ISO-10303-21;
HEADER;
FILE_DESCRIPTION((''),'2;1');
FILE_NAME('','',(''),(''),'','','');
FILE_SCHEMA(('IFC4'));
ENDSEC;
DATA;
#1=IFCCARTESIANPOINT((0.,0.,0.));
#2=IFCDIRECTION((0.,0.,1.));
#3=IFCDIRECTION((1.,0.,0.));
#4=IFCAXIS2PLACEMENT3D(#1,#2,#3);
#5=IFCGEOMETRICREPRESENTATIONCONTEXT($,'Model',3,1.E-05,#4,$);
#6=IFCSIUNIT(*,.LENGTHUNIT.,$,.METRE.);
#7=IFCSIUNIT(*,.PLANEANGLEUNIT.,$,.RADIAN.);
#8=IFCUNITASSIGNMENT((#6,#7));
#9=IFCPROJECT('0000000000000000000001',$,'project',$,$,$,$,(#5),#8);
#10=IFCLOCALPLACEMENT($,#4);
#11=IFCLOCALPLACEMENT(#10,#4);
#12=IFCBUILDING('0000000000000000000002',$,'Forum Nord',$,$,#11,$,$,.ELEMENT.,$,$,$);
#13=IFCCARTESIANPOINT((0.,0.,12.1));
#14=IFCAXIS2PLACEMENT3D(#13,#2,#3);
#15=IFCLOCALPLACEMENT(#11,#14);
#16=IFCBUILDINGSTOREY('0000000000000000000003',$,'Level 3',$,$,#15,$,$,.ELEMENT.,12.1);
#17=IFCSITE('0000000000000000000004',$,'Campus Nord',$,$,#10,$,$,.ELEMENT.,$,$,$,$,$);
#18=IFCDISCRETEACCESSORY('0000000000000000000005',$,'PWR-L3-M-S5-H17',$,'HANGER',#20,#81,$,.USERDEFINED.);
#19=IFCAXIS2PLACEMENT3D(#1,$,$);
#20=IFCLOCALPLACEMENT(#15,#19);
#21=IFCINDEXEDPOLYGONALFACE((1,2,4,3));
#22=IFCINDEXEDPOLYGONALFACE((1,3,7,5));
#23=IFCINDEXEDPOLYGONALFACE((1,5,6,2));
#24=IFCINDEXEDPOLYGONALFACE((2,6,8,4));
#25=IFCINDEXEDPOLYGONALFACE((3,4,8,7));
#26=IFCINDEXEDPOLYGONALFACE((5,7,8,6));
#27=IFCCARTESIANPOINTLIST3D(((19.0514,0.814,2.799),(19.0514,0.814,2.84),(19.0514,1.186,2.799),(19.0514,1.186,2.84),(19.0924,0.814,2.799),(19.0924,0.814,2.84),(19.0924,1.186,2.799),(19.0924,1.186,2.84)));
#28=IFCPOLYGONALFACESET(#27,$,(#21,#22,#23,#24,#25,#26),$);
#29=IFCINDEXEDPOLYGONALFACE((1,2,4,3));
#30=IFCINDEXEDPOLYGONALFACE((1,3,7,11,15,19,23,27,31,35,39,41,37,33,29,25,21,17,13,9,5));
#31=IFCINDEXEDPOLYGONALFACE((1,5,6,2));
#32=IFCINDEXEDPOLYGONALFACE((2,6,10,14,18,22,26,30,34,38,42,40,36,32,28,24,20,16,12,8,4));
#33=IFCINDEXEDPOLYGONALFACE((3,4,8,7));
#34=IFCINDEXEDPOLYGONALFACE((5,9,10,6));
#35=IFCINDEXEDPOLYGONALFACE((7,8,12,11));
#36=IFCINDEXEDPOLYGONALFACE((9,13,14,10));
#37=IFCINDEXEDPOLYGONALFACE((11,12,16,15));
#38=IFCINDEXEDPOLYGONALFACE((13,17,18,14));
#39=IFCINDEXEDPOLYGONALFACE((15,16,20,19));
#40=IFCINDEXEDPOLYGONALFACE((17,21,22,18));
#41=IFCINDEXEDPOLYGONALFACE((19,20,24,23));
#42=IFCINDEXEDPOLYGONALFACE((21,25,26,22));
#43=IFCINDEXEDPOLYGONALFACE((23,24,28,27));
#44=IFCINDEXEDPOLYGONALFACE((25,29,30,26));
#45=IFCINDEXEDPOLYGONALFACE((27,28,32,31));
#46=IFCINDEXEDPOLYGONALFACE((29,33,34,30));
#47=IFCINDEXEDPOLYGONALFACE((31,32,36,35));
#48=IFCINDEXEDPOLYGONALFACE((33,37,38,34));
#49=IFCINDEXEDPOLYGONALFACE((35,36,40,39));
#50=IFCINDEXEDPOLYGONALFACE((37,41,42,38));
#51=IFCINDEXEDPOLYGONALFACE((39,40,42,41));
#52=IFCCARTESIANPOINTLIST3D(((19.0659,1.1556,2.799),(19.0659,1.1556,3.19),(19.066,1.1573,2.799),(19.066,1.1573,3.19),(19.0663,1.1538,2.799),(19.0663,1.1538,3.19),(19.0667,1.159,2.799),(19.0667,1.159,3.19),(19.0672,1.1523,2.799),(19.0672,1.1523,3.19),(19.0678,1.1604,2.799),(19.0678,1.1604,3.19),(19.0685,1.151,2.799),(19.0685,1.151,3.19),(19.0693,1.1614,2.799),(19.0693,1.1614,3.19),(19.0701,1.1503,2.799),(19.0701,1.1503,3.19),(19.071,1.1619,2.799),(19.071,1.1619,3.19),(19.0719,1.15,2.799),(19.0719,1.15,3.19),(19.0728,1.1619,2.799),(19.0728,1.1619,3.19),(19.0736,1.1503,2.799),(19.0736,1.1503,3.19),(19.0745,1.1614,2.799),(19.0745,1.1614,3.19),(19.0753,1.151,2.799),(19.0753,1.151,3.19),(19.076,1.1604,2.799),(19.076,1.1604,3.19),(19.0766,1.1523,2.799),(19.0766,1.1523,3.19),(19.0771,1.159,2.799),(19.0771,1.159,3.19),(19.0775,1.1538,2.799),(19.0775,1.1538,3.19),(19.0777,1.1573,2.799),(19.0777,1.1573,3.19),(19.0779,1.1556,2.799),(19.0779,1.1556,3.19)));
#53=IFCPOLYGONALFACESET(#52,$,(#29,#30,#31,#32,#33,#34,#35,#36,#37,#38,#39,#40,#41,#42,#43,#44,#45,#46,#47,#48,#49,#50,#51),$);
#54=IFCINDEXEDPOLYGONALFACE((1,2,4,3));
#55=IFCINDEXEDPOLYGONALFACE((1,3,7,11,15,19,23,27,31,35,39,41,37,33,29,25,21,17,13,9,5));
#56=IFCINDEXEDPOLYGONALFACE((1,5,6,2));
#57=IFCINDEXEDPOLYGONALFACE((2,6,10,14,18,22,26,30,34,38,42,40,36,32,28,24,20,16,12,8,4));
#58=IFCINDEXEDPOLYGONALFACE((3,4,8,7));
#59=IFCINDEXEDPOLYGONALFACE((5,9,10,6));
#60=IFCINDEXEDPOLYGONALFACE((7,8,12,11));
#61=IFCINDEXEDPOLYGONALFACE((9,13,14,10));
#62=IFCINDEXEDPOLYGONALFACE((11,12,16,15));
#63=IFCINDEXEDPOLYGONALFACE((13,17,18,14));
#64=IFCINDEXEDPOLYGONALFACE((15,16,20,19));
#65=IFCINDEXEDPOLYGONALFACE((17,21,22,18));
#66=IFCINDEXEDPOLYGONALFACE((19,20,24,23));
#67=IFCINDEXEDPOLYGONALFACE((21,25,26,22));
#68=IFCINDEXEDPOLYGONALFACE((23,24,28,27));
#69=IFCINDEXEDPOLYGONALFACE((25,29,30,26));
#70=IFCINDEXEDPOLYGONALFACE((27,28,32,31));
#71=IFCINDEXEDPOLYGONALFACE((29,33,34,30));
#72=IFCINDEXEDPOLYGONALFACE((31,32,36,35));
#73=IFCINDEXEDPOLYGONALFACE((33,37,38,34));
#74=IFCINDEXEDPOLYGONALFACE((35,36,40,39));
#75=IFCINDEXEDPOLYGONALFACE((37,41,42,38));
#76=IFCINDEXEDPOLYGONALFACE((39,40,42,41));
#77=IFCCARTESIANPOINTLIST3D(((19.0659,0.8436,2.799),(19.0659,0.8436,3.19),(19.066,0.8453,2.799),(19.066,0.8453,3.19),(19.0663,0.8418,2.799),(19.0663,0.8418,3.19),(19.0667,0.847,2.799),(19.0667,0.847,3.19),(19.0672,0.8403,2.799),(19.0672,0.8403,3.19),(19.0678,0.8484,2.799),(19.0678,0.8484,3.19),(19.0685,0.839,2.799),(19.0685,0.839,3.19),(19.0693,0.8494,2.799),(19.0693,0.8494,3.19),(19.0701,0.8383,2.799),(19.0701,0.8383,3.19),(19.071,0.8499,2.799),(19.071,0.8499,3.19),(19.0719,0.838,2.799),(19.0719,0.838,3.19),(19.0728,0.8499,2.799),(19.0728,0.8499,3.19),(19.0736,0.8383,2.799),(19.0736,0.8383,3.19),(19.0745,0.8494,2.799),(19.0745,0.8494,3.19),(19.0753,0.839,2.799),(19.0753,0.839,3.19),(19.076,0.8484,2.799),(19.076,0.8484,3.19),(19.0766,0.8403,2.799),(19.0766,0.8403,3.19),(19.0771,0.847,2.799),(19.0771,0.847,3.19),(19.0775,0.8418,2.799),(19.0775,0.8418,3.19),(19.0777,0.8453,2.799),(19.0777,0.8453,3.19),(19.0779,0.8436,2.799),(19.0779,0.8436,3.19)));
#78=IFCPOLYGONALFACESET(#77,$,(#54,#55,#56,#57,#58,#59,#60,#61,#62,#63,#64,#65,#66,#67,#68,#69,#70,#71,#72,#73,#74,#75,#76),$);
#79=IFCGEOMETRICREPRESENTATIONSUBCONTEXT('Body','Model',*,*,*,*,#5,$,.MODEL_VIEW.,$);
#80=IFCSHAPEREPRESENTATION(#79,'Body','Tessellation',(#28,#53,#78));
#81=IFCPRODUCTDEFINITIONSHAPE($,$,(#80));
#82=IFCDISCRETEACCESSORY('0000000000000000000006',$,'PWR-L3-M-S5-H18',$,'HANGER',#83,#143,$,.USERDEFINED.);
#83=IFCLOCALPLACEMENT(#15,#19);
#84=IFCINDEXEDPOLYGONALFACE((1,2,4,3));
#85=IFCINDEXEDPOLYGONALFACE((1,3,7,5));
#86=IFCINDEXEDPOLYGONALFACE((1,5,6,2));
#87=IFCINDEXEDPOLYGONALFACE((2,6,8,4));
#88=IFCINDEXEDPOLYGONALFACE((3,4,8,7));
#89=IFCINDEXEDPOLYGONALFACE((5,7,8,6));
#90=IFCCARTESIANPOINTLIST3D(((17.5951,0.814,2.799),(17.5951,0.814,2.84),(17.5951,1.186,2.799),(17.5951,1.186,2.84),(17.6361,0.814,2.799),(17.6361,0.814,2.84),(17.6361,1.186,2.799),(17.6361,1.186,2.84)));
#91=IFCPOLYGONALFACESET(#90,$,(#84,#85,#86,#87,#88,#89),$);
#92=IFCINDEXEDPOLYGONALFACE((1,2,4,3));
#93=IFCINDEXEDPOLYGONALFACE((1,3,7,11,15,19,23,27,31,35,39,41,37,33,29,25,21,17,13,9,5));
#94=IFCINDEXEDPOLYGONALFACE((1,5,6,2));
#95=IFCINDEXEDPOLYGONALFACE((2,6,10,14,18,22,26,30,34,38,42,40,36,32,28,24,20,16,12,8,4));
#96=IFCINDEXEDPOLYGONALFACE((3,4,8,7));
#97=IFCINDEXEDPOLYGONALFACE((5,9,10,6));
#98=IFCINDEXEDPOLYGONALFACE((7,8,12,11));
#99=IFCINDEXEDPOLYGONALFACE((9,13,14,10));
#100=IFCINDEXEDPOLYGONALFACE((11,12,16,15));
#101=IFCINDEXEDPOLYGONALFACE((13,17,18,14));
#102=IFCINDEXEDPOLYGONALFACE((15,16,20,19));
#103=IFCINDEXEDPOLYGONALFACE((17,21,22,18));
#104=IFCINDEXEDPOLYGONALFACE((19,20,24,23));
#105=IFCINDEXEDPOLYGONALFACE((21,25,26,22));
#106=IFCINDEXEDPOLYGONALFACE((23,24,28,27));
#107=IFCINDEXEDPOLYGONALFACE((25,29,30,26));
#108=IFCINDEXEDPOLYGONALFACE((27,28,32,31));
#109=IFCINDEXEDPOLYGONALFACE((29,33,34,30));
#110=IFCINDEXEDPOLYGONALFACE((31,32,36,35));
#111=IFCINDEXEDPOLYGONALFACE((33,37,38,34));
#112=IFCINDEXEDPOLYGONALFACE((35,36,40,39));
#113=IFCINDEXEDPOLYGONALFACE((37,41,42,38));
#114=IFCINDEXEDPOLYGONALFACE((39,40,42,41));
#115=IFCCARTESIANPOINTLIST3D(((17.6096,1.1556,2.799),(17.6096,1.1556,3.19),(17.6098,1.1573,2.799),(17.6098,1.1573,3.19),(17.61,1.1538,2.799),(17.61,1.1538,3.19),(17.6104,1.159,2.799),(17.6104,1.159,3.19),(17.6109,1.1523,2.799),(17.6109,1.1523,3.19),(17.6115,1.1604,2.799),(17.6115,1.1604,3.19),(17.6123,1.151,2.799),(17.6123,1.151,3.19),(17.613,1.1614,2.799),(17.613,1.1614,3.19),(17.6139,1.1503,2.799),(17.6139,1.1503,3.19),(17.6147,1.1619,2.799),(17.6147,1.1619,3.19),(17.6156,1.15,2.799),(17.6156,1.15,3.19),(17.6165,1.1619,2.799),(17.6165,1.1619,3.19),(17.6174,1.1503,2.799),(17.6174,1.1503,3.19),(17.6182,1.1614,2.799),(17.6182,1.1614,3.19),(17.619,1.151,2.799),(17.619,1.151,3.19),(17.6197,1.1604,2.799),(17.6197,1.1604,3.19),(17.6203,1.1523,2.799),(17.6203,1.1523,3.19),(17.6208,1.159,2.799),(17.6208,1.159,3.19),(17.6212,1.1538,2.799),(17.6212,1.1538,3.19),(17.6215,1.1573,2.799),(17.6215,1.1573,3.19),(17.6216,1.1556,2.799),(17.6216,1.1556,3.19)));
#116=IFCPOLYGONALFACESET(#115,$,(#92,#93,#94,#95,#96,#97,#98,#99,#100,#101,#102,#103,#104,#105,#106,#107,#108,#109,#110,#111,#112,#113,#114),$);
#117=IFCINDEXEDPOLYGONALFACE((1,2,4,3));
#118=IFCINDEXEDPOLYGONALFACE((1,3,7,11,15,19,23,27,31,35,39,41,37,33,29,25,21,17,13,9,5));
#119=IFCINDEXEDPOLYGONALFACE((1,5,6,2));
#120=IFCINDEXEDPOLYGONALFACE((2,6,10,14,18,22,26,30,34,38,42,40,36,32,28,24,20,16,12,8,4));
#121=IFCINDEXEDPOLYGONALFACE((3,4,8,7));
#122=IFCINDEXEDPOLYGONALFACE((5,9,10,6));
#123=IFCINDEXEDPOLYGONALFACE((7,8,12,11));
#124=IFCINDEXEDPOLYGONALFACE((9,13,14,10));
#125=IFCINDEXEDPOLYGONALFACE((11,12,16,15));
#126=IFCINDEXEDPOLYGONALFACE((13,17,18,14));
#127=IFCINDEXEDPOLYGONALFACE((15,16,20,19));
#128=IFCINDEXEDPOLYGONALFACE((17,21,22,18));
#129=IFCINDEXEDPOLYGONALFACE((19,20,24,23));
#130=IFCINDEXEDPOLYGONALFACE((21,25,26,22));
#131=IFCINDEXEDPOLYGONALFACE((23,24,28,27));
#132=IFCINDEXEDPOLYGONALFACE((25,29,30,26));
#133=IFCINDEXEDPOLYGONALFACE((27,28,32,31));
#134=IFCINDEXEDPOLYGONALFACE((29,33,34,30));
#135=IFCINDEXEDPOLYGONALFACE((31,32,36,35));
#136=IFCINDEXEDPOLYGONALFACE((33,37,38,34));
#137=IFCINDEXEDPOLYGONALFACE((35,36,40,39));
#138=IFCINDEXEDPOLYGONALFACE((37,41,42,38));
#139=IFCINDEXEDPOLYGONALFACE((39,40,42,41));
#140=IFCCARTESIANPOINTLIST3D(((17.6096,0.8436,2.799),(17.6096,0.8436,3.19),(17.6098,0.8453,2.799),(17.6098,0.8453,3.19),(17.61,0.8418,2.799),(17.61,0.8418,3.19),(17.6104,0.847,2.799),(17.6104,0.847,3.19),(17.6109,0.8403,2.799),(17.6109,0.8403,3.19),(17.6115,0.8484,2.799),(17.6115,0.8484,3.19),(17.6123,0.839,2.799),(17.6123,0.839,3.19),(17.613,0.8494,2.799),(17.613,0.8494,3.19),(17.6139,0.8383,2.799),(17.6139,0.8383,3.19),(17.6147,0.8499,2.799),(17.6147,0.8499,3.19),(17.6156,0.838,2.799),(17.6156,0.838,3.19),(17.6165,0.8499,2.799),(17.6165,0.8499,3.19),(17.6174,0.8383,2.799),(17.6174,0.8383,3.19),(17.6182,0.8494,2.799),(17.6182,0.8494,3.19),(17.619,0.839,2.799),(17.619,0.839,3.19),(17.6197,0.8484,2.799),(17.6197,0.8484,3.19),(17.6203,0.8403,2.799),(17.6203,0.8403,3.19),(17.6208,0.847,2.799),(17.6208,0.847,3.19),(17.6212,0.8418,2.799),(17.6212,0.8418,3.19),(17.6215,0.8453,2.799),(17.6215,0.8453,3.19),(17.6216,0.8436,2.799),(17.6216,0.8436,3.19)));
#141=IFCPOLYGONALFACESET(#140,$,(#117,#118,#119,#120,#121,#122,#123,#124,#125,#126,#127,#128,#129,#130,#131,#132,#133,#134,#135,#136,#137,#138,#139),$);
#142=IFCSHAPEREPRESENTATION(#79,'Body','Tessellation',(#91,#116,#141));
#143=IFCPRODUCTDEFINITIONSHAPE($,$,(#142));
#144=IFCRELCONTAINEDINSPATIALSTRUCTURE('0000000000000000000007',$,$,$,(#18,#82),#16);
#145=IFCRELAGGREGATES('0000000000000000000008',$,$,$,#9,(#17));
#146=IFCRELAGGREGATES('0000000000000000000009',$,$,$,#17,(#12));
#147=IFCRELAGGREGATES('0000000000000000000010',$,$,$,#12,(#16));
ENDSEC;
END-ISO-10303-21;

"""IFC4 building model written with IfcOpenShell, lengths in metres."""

from ifc_helpers import new_model, si_unit, frame, frame_2d, origin_with_axes, origin_2d_with_axis, place, context, subcontext, project, spatial, rectangle, circle, extrude, element, save


model = new_model("IFC4")

# Units and contexts
model_context = context("Model", 3, precision=1e-05, world=origin_with_axes())
body_context = subcontext(model_context, "Body", "Model", "MODEL_VIEW")
ifc_project = project(units=[si_unit("LENGTHUNIT", "METRE"), si_unit("PLANEANGLEUNIT", "RADIAN")], contexts=[model_context])

# Site, building, storey
site_placement = place(None, origin_with_axes())
site = spatial("IfcSite", under=ifc_project, at=site_placement, Name="Campus Nord", CompositionType="ELEMENT")
building_placement = place(site_placement, origin_with_axes())
building = spatial("IfcBuilding", under=site, at=building_placement, Name="Forum Nord", CompositionType="ELEMENT")
storey_placement = place(building_placement, frame((0.0, 0.0, 12.1), z_axis=(0.0, 0.0, 1.0), x_axis=(1.0, 0.0, 0.0)))
storey = spatial("IfcBuildingStorey", under=building, at=storey_placement, Name="Level 3", CompositionType="ELEMENT", Elevation=12.1)

# Discrete accessories
for number, where, z_axis, x_axis, name in (
    (1, (19.0719, 1.0, 2.84), (0.0, 0.0, 1.0), (0.0, -1.0, 0.0), "PWR-L3-M-S5-H17"),
    (2, (17.6156, 1.0, 2.84), (0.0, 0.0, 1.0), (0.0, -1.0, 0.0), "PWR-L3-M-S5-H18"),
):
    element("IfcDiscreteAccessory", number, at=place(storey_placement, frame(where, z_axis=z_axis, x_axis=x_axis)), inside=storey, Name=name, ObjectType="HANGER", PredefinedType="USERDEFINED", context=body_context, shape_type="SweptSolid", body=[
        extrude(rectangle(XDim=0.372, YDim=0.041, at=origin_2d_with_axis()), frame((0.0, 0.0, -0.041), z_axis=(0.0, 0.0, 1.0), x_axis=(1.0, 0.0, 0.0)), (0.0, 0.0, 1.0), 0.041),
        extrude(circle(Radius=0.006, at=frame_2d((-0.156, 0.0), x_axis=(1.0, 0.0))), frame((0.0, 0.0, -0.041), z_axis=(0.0, 0.0, 1.0), x_axis=(1.0, 0.0, 0.0)), (0.0, 0.0, 1.0), 0.391),
        extrude(circle(Radius=0.006, at=frame_2d((0.156, 0.0), x_axis=(1.0, 0.0))), frame((0.0, 0.0, -0.041), z_axis=(0.0, 0.0, 1.0), x_axis=(1.0, 0.0, 0.0)), (0.0, 0.0, 1.0), 0.391),
    ])

save(model, "model.ifc")
